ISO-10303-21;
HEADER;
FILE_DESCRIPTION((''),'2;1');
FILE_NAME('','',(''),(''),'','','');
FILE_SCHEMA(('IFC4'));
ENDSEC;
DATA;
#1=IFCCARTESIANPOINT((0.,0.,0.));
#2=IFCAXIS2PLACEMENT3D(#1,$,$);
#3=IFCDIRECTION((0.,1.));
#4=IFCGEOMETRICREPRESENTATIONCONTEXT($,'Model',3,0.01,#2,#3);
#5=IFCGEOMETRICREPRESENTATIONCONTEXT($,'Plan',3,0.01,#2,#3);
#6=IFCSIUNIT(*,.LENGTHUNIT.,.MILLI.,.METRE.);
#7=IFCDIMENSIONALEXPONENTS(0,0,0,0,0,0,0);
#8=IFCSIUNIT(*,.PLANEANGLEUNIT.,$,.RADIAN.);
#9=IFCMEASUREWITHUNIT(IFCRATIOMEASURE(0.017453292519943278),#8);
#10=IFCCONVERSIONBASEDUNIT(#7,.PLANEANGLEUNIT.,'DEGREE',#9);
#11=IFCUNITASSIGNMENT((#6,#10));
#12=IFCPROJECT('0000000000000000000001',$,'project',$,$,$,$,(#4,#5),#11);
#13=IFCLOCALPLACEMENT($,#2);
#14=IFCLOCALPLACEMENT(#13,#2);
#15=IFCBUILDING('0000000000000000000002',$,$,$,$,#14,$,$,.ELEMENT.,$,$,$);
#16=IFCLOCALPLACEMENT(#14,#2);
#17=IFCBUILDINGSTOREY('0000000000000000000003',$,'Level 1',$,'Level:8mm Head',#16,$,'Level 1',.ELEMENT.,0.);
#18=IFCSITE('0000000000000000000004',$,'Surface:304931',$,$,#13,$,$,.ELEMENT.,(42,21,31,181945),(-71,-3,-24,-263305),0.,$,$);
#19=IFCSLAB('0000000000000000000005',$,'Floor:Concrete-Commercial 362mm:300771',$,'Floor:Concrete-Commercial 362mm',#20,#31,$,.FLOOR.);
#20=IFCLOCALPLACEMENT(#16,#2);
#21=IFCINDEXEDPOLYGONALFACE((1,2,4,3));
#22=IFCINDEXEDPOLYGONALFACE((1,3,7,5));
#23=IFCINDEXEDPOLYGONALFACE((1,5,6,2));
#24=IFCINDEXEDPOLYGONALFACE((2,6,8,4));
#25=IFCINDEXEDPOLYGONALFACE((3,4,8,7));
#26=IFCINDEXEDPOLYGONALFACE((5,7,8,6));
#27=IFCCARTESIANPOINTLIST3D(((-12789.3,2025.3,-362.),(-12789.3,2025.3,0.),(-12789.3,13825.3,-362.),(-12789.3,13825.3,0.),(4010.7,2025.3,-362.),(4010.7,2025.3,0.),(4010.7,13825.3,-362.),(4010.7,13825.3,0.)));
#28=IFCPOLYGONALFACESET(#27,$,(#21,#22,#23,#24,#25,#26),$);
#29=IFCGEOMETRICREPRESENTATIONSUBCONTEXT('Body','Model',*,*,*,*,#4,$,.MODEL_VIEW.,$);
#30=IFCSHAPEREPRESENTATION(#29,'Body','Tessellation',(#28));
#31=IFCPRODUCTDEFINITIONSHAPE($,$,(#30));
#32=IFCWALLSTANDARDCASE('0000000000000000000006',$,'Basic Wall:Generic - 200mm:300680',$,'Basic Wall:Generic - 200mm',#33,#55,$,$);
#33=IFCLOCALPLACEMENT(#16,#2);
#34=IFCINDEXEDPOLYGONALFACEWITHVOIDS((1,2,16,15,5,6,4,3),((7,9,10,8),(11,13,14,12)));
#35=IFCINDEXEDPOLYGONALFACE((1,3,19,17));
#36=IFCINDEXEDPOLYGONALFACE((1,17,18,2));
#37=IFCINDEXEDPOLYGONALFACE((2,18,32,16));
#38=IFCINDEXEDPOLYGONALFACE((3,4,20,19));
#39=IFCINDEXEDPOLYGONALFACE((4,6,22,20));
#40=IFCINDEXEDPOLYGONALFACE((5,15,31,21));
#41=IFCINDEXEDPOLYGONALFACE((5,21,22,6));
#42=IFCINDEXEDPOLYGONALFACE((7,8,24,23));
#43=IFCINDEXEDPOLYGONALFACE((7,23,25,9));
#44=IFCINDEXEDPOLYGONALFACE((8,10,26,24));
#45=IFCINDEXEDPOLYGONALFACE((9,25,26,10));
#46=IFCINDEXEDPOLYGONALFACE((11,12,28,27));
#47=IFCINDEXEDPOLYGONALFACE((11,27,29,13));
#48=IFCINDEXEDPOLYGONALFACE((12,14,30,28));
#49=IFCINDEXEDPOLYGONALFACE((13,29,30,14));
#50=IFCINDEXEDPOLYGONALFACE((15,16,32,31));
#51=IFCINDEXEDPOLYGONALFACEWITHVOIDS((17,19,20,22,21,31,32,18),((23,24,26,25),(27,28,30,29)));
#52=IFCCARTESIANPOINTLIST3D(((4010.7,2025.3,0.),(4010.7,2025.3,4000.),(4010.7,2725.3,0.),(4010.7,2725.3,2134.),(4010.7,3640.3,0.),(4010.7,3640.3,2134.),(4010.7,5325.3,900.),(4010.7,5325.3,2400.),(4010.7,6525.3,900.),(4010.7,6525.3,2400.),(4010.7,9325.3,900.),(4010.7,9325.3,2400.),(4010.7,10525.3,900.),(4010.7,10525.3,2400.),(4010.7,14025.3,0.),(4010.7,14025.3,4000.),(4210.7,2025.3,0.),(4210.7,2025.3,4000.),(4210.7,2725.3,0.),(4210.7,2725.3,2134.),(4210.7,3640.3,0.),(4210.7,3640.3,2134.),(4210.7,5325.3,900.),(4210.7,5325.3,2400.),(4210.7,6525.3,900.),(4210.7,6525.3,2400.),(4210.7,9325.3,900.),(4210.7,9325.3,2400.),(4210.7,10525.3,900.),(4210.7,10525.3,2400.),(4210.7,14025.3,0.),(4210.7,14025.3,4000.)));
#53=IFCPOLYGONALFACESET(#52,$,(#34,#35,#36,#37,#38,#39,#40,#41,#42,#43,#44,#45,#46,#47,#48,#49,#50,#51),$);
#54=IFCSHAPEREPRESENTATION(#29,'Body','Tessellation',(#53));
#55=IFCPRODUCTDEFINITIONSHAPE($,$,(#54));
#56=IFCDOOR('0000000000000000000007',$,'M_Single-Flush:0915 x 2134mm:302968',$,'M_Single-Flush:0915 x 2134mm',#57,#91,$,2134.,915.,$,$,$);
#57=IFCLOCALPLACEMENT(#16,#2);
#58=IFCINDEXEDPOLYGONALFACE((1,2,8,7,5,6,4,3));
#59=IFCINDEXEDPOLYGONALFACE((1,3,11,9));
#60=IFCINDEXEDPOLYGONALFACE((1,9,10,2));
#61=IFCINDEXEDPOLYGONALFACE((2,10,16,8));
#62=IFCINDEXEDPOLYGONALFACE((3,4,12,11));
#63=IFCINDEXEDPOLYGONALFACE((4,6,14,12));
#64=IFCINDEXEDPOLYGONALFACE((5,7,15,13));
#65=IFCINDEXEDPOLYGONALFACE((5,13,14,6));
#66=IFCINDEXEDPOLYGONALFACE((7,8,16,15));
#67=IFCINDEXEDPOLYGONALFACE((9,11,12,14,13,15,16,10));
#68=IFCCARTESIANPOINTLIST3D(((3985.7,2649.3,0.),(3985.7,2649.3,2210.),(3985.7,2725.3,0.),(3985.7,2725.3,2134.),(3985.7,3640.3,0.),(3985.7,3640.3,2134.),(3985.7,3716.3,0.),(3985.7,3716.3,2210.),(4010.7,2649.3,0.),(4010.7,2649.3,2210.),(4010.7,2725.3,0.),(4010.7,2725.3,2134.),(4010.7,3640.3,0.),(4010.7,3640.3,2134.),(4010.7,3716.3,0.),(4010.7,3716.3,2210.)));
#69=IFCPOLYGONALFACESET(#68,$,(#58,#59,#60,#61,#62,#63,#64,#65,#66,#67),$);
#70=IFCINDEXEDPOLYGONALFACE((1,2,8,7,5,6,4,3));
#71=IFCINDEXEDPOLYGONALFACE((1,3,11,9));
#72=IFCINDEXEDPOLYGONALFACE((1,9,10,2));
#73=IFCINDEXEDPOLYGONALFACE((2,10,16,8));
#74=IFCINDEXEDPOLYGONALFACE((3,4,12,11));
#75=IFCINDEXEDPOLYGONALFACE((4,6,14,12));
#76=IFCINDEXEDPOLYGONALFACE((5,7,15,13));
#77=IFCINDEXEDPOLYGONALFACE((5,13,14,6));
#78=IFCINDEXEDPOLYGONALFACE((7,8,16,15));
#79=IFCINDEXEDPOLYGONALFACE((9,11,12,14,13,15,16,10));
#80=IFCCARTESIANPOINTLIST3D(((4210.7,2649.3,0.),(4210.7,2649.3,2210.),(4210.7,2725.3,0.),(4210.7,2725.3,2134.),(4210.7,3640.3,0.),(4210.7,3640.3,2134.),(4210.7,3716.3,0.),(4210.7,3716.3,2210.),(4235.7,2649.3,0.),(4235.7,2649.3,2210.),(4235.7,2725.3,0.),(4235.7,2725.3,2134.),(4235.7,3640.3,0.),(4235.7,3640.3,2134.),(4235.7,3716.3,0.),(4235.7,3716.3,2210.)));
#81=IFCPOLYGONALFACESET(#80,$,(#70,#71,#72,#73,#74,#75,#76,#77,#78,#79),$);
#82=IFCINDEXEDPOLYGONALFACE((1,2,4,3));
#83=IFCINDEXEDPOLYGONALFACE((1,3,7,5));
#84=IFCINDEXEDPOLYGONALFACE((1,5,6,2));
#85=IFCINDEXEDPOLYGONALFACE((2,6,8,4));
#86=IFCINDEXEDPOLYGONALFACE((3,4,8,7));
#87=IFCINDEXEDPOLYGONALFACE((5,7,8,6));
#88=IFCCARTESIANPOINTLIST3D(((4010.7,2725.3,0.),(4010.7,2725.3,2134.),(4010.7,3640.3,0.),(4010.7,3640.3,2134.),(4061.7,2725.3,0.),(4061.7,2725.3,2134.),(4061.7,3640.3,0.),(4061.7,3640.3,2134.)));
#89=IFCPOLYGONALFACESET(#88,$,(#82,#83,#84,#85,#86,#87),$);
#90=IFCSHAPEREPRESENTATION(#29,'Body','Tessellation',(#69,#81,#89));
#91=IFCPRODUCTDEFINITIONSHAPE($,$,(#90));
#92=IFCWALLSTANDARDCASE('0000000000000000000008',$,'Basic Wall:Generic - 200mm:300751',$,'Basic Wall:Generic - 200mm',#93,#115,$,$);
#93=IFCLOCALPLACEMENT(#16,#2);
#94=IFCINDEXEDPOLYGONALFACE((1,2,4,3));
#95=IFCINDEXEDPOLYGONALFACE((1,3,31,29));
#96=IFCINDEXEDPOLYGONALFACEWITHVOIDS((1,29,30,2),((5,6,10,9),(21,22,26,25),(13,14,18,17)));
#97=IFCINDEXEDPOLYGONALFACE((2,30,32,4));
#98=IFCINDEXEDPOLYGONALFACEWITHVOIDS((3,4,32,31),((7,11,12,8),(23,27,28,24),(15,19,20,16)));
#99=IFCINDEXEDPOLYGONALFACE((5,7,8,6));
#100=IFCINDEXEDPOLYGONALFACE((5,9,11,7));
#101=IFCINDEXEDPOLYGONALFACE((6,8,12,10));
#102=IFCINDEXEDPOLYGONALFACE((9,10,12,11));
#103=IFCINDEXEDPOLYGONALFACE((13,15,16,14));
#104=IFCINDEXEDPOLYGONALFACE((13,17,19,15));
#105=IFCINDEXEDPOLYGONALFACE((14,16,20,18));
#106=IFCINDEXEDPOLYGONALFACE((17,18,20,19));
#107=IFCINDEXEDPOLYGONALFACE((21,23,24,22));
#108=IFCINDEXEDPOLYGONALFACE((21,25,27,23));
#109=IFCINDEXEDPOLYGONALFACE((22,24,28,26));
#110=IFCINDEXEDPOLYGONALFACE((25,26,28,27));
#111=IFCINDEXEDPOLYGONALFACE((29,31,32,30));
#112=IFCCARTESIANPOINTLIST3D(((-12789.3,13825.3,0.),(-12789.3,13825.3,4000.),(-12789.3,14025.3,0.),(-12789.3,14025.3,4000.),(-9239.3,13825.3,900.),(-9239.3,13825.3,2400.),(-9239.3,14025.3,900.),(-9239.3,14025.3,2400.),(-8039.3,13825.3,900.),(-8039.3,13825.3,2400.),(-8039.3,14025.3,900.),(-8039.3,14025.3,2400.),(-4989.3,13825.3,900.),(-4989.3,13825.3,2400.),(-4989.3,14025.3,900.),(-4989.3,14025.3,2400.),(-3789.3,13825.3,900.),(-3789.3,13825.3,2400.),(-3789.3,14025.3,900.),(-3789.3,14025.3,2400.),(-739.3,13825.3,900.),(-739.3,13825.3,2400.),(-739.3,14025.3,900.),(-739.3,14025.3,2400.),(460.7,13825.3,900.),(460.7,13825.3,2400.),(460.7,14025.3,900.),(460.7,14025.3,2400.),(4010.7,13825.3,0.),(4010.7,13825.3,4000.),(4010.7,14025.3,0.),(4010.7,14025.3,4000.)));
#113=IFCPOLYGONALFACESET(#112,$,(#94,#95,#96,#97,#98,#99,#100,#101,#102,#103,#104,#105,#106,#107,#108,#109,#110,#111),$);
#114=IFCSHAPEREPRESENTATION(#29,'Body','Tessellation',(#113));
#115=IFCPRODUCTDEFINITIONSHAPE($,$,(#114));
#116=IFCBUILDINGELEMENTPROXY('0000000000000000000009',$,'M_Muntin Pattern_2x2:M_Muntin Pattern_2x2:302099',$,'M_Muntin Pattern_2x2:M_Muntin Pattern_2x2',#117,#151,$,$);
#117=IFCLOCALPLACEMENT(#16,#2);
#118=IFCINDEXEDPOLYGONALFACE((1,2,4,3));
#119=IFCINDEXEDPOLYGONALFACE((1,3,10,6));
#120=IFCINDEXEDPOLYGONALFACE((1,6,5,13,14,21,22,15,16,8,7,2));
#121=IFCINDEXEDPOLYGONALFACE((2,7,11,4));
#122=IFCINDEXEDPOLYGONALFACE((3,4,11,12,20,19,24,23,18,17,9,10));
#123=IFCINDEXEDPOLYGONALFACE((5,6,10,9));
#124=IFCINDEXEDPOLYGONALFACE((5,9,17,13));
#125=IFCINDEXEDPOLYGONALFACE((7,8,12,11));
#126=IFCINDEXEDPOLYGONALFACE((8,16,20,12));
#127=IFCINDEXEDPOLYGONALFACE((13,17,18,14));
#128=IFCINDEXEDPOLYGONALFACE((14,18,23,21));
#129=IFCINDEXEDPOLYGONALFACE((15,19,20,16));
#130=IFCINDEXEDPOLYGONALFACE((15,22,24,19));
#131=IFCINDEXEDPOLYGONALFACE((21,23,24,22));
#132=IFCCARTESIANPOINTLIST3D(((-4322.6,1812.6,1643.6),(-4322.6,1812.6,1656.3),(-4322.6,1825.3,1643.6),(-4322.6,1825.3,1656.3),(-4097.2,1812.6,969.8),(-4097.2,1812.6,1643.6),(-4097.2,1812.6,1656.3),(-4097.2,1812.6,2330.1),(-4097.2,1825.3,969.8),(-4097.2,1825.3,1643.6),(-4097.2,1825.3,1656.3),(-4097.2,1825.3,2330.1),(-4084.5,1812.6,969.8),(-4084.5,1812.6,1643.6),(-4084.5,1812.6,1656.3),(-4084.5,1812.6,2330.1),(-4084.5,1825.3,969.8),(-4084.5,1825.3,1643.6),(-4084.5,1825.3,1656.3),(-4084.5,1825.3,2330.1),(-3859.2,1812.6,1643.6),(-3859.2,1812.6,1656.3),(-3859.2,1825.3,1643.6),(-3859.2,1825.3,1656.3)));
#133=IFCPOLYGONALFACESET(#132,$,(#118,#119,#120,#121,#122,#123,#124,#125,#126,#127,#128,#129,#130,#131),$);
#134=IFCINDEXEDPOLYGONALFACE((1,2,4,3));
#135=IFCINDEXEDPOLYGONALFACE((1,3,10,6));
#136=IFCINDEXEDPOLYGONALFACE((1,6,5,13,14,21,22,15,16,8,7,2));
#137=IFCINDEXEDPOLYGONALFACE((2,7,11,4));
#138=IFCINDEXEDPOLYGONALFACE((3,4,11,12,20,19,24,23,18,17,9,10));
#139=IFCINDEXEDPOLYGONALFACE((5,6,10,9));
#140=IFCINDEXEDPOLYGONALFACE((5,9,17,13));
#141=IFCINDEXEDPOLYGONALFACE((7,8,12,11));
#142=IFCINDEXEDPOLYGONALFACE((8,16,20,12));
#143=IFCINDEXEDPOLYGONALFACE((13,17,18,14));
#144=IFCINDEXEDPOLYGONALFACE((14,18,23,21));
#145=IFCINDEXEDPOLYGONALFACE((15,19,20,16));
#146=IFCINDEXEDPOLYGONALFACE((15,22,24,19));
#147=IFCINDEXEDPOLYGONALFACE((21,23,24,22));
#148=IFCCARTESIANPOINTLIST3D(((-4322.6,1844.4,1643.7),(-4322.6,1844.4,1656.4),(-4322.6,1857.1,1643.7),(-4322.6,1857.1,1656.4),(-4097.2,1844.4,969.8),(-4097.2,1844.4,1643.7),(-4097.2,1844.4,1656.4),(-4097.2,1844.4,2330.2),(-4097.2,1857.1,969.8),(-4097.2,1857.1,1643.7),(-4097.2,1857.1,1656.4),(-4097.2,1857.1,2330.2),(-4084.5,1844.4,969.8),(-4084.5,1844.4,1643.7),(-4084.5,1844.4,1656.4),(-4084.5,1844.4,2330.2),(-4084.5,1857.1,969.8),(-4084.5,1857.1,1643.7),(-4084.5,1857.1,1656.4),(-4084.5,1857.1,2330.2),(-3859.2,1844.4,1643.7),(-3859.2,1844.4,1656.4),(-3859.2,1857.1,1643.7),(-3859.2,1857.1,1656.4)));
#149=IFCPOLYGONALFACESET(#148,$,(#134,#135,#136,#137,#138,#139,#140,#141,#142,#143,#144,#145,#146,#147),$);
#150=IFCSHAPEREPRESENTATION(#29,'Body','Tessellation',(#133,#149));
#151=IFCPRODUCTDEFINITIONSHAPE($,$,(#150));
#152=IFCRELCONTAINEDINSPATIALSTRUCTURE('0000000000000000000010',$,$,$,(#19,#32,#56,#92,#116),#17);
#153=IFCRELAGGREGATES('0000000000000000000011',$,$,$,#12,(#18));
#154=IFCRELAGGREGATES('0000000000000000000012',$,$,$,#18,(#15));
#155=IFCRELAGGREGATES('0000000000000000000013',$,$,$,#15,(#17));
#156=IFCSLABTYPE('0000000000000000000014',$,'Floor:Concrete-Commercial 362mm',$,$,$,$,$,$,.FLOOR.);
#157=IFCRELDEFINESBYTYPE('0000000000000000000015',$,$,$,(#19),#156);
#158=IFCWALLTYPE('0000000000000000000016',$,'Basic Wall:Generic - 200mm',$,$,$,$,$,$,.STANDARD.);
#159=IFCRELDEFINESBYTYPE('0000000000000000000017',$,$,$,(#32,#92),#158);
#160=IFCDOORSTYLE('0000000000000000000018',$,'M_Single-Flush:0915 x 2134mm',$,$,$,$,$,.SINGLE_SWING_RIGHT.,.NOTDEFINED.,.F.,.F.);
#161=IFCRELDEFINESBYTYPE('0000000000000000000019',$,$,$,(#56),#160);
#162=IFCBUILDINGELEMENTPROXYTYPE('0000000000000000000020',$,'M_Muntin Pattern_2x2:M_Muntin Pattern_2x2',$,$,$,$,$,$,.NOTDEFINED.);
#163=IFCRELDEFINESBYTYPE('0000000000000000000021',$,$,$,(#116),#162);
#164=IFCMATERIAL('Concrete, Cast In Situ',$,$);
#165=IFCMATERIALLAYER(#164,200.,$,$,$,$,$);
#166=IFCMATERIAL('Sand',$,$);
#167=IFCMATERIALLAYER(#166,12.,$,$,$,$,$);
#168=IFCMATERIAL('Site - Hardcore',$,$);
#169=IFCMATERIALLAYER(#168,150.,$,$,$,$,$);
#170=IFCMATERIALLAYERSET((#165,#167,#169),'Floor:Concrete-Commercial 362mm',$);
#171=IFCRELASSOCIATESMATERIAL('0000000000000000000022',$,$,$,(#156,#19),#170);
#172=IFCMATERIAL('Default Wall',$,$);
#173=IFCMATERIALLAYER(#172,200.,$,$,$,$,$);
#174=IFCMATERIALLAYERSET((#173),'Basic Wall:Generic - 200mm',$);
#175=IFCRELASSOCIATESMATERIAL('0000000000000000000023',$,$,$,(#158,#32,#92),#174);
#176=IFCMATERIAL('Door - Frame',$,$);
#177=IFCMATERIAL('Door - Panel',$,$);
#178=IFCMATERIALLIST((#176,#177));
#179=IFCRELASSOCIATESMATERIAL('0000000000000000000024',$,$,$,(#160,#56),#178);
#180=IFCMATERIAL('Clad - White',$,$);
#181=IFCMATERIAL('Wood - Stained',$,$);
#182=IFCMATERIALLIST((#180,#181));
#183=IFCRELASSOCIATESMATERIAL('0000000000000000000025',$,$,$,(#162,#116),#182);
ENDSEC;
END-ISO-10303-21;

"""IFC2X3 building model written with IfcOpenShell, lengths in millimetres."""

from ifc_helpers import new_model, entity, si_unit, converted_unit, direction, frame, frame_2d, origin, place, context, subcontext, project, spatial, polyline, rectangle, outline, extrude, source, transform, mapped, material, material_list, layer, layer_set, layer_usage, type_object, type_shapes, element, fill, save


model = new_model("IFC2X3")

# Units and contexts
model_context = context("Model", 3, precision=0.01, world=origin(), true_north=direction((0.0, 1.0)))
plan_context = context("Plan", 3, precision=0.01, world=origin(), true_north=direction((0.0, 1.0)))
body_context = subcontext(model_context, "Body", "Model", "MODEL_VIEW")
ifc_project = project(units=[si_unit("LENGTHUNIT", "METRE", prefix="MILLI"), converted_unit("PLANEANGLEUNIT", "DEGREE", entity("IfcRatioMeasure", 0.017453292519943278), si_unit("PLANEANGLEUNIT", "RADIAN"), dimensions=[0, 0, 0, 0, 0, 0, 0])], contexts=[model_context, plan_context])

# Site, building, storey
site_placement = place(None, origin())
site = spatial("IfcSite", under=ifc_project, at=site_placement, Name="Surface:304931", CompositionType="ELEMENT", RefLatitude=(42, 21, 31, 181945), RefLongitude=(-71, -3, -24, -263305), RefElevation=0.0)
building_placement = place(site_placement, origin())
building = spatial("IfcBuilding", under=site, at=building_placement, CompositionType="ELEMENT")
storey_placement = place(building_placement, origin())
storey = spatial("IfcBuildingStorey", under=building, at=storey_placement, Name="Level 1", ObjectType="Level:8mm Head", LongName="Level 1", CompositionType="ELEMENT", Elevation=0.0)

# Slab
ifc_material_1 = material(Name="Concrete, Cast In Situ")
ifc_layer_1 = layer(ifc_material_1, 200.0)
ifc_material_2 = material(Name="Sand")
ifc_layer_2 = layer(ifc_material_2, 12.0)
ifc_material_3 = material(Name="Site - Hardcore")
ifc_layer_3 = layer(ifc_material_3, 150.0)
ifc_layer_set_1 = layer_set([ifc_layer_1, ifc_layer_2, ifc_layer_3], Name="Floor:Concrete-Commercial 362mm")
ifc_layer_usage_1 = layer_usage(ifc_layer_set_1, "AXIS3", "POSITIVE", 0.0)
slab_type = type_object("IfcSlabType", Name="Floor:Concrete-Commercial 362mm", PredefinedType="FLOOR", material=ifc_layer_set_1)
slab_placement = place(storey_placement, origin())
element("IfcSlab", 1, at=slab_placement, inside=storey, type_object=slab_type, material=ifc_layer_usage_1, Name="Floor:Concrete-Commercial 362mm:300771", ObjectType="Floor:Concrete-Commercial 362mm", PredefinedType="FLOOR", context=body_context, shape_type="SweptSolid", body=[
    extrude(rectangle(XDim=11800.0, YDim=16800.0, at=frame_2d((0.0, 0.0), x_axis=(1.0, 0.0))), frame((-4389.3, 7925.3, 0.0), z_axis=(0.0, 0.0, -1.0), x_axis=(0.0, 1.0, 0.0)), (0.0, 0.0, 1.0), 362.0),
])

# Wall, openings, door
ifc_material_4 = material(Name="Default Wall")
ifc_layer_4 = layer(ifc_material_4, 200.0)
ifc_layer_set_2 = layer_set([ifc_layer_4], Name="Basic Wall:Generic - 200mm")
ifc_layer_usage_2 = layer_usage(ifc_layer_set_2, "AXIS2", "NEGATIVE", 100.0)
wall_type = type_object("IfcWallType", Name="Basic Wall:Generic - 200mm", PredefinedType="STANDARD", material=ifc_layer_set_2)
wall_1_placement = place(storey_placement, frame((4110.7, 2025.3, 0.0), z_axis=(0.0, 0.0, 1.0), x_axis=(0.0, 1.0, 0.0)))
wall_1 = element("IfcWallStandardCase", 2, at=wall_1_placement, inside=storey, type_object=wall_type, material=ifc_layer_usage_2, Name="Basic Wall:Generic - 200mm:300680", ObjectType="Basic Wall:Generic - 200mm", context=body_context, shape_type="SweptSolid", body=[
    extrude(rectangle(XDim=12000.0, YDim=200.0, at=frame_2d((6000.0, 0.0), x_axis=(-1.0, 0.0))), origin(), (0.0, 0.0, 1.0), 4000.0),
])
opening_1_placement = place(wall_1_placement, frame((700.0, -100.0, 0.0)))
opening_1 = element("IfcOpeningElement", 3, at=opening_1_placement, cuts=wall_1, ObjectType="Opening", context=body_context, shape_type="SweptSolid", body=[
    extrude(rectangle(XDim=915.0, YDim=2134.0, at=frame_2d((1067.0, 457.5), x_axis=(0.0, 1.0))), frame((0.0, 0.0, 0.0), z_axis=(0.0, 1.0, 0.0), x_axis=(0.0, 0.0, 1.0)), (0.0, 0.0, 1.0), 200.0),
])
opening_2_placement = place(wall_1_placement, frame((4500.0, 100.0, 900.0)))
element("IfcOpeningElement", 4, at=opening_2_placement, cuts=wall_1, ObjectType="Opening", context=body_context, shape_type="SweptSolid", body=[
    extrude(rectangle(XDim=1500.0, YDim=1200.0, at=frame_2d((750.0, 600.0), x_axis=(-1.0, 0.0))), frame((0.0, 0.0, 0.0), z_axis=(0.0, -1.0, 0.0), x_axis=(0.0, 0.0, 1.0)), (0.0, 0.0, 1.0), 200.0),
])
opening_3_placement = place(wall_1_placement, frame((8500.0, 100.0, 900.0)))
element("IfcOpeningElement", 5, at=opening_3_placement, cuts=wall_1, ObjectType="Opening", context=body_context, shape_type="SweptSolid", body=[
    extrude(rectangle(XDim=1500.0, YDim=1200.0, at=frame_2d((750.0, 600.0), x_axis=(-1.0, 0.0))), frame((0.0, 0.0, 0.0), z_axis=(0.0, -1.0, 0.0), x_axis=(0.0, 0.0, 1.0)), (0.0, 0.0, 1.0), 200.0),
])
ifc_material_5 = material(Name="Door - Frame")
ifc_material_6 = material(Name="Door - Panel")
ifc_material_list_1 = material_list([ifc_material_5, ifc_material_6])
door_style = type_object("IfcDoorStyle", Name="M_Single-Flush:0915 x 2134mm", ConstructionType="NOTDEFINED", OperationType="SINGLE_SWING_RIGHT", ParameterTakesPrecedence=False, Sizeable=False, material=ifc_material_list_1)
shared_shape_1 = source(origin(), body_context, "Body", "SweptSolid", [
    extrude(outline(polyline([(-533.5, -1124.0), (533.5, -1124.0), (533.5, 1086.0), (457.5, 1086.0), (457.5, -1048.0), (-457.5, -1048.0), (-457.5, 1086.0), (-533.5, 1086.0), (-533.5, -1124.0)])), frame((457.5, 200.0, 1086.0), z_axis=(0.0, 1.0, 0.0), x_axis=(1.0, 0.0, 0.0)), (0.0, 0.0, 1.0), 25.0),
    extrude(outline(polyline([(-1124.0, -533.5), (1086.0, -533.5), (1086.0, -457.5), (-1048.0, -457.5), (-1048.0, 457.5), (1086.0, 457.5), (1086.0, 533.5), (-1124.0, 533.5), (-1124.0, -533.5)])), frame((457.5, -25.0, 1086.0), z_axis=(0.0, 1.0, 0.0), x_axis=(0.0, 0.0, -1.0)), (0.0, 0.0, 1.0), 25.0),
    extrude(rectangle(XDim=51.0, YDim=915.0, at=frame_2d((0.0, 0.0), x_axis=(1.0, 0.0))), frame((457.5, 174.5, 0.0), z_axis=(0.0, 0.0, 1.0), x_axis=(0.0, 1.0, 0.0)), (0.0, 0.0, 1.0), 2134.0),
])
type_shapes(door_style, [shared_shape_1])
door_placement = place(opening_1_placement, origin())
door = element("IfcDoor", 6, at=door_placement, inside=storey, type_object=door_style, material=ifc_material_list_1, Name="M_Single-Flush:0915 x 2134mm:302968", ObjectType="M_Single-Flush:0915 x 2134mm", OverallHeight=2134.0, OverallWidth=915.0, context=body_context, shape_type="MappedRepresentation", body=[
    mapped(shared_shape_1, transform((0.0, 0.0, 0.0), scale=1.0)),
])
fill(opening_1, door)

# Wall, openings
wall_2_placement = place(storey_placement, frame((4010.7, 13925.3, 0.0), z_axis=(0.0, 0.0, 1.0), x_axis=(-1.0, 0.0, 0.0)))
wall_2 = element("IfcWallStandardCase", 7, at=wall_2_placement, inside=storey, type_object=wall_type, material=ifc_layer_usage_2, Name="Basic Wall:Generic - 200mm:300751", ObjectType="Basic Wall:Generic - 200mm", context=body_context, shape_type="SweptSolid", body=[
    extrude(rectangle(XDim=16800.0, YDim=200.0, at=frame_2d((8400.0, 0.0), x_axis=(-1.0, 0.0))), origin(), (0.0, 0.0, 1.0), 4000.0),
])
opening_4_placement = place(wall_2_placement, frame((4750.0, 100.0, 900.0)))
element("IfcOpeningElement", 8, at=opening_4_placement, cuts=wall_2, ObjectType="Opening", context=body_context, shape_type="SweptSolid", body=[
    extrude(rectangle(XDim=1500.0, YDim=1200.0, at=frame_2d((750.0, 600.0), x_axis=(-1.0, 0.0))), frame((0.0, 0.0, 0.0), z_axis=(0.0, -1.0, 0.0), x_axis=(0.0, 0.0, 1.0)), (0.0, 0.0, 1.0), 200.0),
])
opening_5_placement = place(wall_2_placement, frame((9000.0, 100.0, 900.0)))
element("IfcOpeningElement", 9, at=opening_5_placement, cuts=wall_2, ObjectType="Opening", context=body_context, shape_type="SweptSolid", body=[
    extrude(rectangle(XDim=1500.0, YDim=1200.0, at=frame_2d((750.0, 600.0), x_axis=(-1.0, 0.0))), frame((0.0, 0.0, 0.0), z_axis=(0.0, -1.0, 0.0), x_axis=(0.0, 0.0, 1.0)), (0.0, 0.0, 1.0), 200.0),
])
opening_6_placement = place(wall_2_placement, frame((13250.0, 100.0, 900.0)))
element("IfcOpeningElement", 10, at=opening_6_placement, cuts=wall_2, ObjectType="Opening", context=body_context, shape_type="SweptSolid", body=[
    extrude(rectangle(XDim=1500.0, YDim=1200.0, at=frame_2d((750.0, 600.0), x_axis=(-1.0, 0.0))), frame((0.0, 0.0, 0.0), z_axis=(0.0, -1.0, 0.0), x_axis=(0.0, 0.0, 1.0)), (0.0, 0.0, 1.0), 200.0),
])

# Building element proxy
ifc_material_7 = material(Name="Clad - White")
ifc_material_8 = material(Name="Wood - Stained")
ifc_material_list_2 = material_list([ifc_material_7, ifc_material_8])
building_element_proxy_type_1 = type_object("IfcBuildingElementProxyType", Name="M_Muntin Pattern_2x2:M_Muntin Pattern_2x2", PredefinedType="NOTDEFINED", material=ifc_material_list_2)
shared_shape_2 = source(origin(), body_context, "Body", "SweptSolid", [
    extrude(outline(polyline([(6.4, -6.4), (680.1, -6.4), (680.1, 6.3), (6.4, 6.3), (6.4, 231.7), (-6.3, 231.7), (-6.3, 6.3), (-680.2, 6.3), (-680.2, -6.4), (-6.3, -6.4), (-6.3, -231.7), (6.4, -231.7), (6.4, -6.4)])), frame((0.0, 9.5, 680.1), z_axis=(0.0, 1.0, 0.0), x_axis=(0.0, 0.0, 1.0)), (0.0, 0.0, 1.0), 12.7),
    extrude(outline(polyline([(6.4, -6.4), (680.2, -6.4), (680.2, 6.3), (6.4, 6.3), (6.4, 231.7), (-6.3, 231.7), (-6.3, 6.3), (-680.2, 6.3), (-680.2, -6.4), (-6.3, -6.4), (-6.3, -231.7), (6.4, -231.7), (6.4, -6.4)])), frame((0.0, -22.2, 680.2), z_axis=(0.0, 1.0, 0.0), x_axis=(0.0, 0.0, 1.0)), (0.0, 0.0, 1.0), 12.7),
])
type_shapes(building_element_proxy_type_1, [shared_shape_2])
for number, where, z_axis, x_axis, name in (
    (11, (-4090.9, 1834.8, 969.8), (0.0, 0.0, 1.0), (-1.0, 0.0, 0.0), "M_Muntin Pattern_2x2:M_Muntin Pattern_2x2:302099"),
):
    element("IfcBuildingElementProxy", number, at=place(storey_placement, frame(where, z_axis=z_axis, x_axis=x_axis)), inside=storey, type_object=building_element_proxy_type_1, material=ifc_material_list_2, Name=name, ObjectType="M_Muntin Pattern_2x2:M_Muntin Pattern_2x2", context=body_context, shape_type="MappedRepresentation", body=[
        mapped(shared_shape_2, transform((0.0, 0.0, 0.0), scale=1.0)),
    ])

save(model, "model.ifc")
